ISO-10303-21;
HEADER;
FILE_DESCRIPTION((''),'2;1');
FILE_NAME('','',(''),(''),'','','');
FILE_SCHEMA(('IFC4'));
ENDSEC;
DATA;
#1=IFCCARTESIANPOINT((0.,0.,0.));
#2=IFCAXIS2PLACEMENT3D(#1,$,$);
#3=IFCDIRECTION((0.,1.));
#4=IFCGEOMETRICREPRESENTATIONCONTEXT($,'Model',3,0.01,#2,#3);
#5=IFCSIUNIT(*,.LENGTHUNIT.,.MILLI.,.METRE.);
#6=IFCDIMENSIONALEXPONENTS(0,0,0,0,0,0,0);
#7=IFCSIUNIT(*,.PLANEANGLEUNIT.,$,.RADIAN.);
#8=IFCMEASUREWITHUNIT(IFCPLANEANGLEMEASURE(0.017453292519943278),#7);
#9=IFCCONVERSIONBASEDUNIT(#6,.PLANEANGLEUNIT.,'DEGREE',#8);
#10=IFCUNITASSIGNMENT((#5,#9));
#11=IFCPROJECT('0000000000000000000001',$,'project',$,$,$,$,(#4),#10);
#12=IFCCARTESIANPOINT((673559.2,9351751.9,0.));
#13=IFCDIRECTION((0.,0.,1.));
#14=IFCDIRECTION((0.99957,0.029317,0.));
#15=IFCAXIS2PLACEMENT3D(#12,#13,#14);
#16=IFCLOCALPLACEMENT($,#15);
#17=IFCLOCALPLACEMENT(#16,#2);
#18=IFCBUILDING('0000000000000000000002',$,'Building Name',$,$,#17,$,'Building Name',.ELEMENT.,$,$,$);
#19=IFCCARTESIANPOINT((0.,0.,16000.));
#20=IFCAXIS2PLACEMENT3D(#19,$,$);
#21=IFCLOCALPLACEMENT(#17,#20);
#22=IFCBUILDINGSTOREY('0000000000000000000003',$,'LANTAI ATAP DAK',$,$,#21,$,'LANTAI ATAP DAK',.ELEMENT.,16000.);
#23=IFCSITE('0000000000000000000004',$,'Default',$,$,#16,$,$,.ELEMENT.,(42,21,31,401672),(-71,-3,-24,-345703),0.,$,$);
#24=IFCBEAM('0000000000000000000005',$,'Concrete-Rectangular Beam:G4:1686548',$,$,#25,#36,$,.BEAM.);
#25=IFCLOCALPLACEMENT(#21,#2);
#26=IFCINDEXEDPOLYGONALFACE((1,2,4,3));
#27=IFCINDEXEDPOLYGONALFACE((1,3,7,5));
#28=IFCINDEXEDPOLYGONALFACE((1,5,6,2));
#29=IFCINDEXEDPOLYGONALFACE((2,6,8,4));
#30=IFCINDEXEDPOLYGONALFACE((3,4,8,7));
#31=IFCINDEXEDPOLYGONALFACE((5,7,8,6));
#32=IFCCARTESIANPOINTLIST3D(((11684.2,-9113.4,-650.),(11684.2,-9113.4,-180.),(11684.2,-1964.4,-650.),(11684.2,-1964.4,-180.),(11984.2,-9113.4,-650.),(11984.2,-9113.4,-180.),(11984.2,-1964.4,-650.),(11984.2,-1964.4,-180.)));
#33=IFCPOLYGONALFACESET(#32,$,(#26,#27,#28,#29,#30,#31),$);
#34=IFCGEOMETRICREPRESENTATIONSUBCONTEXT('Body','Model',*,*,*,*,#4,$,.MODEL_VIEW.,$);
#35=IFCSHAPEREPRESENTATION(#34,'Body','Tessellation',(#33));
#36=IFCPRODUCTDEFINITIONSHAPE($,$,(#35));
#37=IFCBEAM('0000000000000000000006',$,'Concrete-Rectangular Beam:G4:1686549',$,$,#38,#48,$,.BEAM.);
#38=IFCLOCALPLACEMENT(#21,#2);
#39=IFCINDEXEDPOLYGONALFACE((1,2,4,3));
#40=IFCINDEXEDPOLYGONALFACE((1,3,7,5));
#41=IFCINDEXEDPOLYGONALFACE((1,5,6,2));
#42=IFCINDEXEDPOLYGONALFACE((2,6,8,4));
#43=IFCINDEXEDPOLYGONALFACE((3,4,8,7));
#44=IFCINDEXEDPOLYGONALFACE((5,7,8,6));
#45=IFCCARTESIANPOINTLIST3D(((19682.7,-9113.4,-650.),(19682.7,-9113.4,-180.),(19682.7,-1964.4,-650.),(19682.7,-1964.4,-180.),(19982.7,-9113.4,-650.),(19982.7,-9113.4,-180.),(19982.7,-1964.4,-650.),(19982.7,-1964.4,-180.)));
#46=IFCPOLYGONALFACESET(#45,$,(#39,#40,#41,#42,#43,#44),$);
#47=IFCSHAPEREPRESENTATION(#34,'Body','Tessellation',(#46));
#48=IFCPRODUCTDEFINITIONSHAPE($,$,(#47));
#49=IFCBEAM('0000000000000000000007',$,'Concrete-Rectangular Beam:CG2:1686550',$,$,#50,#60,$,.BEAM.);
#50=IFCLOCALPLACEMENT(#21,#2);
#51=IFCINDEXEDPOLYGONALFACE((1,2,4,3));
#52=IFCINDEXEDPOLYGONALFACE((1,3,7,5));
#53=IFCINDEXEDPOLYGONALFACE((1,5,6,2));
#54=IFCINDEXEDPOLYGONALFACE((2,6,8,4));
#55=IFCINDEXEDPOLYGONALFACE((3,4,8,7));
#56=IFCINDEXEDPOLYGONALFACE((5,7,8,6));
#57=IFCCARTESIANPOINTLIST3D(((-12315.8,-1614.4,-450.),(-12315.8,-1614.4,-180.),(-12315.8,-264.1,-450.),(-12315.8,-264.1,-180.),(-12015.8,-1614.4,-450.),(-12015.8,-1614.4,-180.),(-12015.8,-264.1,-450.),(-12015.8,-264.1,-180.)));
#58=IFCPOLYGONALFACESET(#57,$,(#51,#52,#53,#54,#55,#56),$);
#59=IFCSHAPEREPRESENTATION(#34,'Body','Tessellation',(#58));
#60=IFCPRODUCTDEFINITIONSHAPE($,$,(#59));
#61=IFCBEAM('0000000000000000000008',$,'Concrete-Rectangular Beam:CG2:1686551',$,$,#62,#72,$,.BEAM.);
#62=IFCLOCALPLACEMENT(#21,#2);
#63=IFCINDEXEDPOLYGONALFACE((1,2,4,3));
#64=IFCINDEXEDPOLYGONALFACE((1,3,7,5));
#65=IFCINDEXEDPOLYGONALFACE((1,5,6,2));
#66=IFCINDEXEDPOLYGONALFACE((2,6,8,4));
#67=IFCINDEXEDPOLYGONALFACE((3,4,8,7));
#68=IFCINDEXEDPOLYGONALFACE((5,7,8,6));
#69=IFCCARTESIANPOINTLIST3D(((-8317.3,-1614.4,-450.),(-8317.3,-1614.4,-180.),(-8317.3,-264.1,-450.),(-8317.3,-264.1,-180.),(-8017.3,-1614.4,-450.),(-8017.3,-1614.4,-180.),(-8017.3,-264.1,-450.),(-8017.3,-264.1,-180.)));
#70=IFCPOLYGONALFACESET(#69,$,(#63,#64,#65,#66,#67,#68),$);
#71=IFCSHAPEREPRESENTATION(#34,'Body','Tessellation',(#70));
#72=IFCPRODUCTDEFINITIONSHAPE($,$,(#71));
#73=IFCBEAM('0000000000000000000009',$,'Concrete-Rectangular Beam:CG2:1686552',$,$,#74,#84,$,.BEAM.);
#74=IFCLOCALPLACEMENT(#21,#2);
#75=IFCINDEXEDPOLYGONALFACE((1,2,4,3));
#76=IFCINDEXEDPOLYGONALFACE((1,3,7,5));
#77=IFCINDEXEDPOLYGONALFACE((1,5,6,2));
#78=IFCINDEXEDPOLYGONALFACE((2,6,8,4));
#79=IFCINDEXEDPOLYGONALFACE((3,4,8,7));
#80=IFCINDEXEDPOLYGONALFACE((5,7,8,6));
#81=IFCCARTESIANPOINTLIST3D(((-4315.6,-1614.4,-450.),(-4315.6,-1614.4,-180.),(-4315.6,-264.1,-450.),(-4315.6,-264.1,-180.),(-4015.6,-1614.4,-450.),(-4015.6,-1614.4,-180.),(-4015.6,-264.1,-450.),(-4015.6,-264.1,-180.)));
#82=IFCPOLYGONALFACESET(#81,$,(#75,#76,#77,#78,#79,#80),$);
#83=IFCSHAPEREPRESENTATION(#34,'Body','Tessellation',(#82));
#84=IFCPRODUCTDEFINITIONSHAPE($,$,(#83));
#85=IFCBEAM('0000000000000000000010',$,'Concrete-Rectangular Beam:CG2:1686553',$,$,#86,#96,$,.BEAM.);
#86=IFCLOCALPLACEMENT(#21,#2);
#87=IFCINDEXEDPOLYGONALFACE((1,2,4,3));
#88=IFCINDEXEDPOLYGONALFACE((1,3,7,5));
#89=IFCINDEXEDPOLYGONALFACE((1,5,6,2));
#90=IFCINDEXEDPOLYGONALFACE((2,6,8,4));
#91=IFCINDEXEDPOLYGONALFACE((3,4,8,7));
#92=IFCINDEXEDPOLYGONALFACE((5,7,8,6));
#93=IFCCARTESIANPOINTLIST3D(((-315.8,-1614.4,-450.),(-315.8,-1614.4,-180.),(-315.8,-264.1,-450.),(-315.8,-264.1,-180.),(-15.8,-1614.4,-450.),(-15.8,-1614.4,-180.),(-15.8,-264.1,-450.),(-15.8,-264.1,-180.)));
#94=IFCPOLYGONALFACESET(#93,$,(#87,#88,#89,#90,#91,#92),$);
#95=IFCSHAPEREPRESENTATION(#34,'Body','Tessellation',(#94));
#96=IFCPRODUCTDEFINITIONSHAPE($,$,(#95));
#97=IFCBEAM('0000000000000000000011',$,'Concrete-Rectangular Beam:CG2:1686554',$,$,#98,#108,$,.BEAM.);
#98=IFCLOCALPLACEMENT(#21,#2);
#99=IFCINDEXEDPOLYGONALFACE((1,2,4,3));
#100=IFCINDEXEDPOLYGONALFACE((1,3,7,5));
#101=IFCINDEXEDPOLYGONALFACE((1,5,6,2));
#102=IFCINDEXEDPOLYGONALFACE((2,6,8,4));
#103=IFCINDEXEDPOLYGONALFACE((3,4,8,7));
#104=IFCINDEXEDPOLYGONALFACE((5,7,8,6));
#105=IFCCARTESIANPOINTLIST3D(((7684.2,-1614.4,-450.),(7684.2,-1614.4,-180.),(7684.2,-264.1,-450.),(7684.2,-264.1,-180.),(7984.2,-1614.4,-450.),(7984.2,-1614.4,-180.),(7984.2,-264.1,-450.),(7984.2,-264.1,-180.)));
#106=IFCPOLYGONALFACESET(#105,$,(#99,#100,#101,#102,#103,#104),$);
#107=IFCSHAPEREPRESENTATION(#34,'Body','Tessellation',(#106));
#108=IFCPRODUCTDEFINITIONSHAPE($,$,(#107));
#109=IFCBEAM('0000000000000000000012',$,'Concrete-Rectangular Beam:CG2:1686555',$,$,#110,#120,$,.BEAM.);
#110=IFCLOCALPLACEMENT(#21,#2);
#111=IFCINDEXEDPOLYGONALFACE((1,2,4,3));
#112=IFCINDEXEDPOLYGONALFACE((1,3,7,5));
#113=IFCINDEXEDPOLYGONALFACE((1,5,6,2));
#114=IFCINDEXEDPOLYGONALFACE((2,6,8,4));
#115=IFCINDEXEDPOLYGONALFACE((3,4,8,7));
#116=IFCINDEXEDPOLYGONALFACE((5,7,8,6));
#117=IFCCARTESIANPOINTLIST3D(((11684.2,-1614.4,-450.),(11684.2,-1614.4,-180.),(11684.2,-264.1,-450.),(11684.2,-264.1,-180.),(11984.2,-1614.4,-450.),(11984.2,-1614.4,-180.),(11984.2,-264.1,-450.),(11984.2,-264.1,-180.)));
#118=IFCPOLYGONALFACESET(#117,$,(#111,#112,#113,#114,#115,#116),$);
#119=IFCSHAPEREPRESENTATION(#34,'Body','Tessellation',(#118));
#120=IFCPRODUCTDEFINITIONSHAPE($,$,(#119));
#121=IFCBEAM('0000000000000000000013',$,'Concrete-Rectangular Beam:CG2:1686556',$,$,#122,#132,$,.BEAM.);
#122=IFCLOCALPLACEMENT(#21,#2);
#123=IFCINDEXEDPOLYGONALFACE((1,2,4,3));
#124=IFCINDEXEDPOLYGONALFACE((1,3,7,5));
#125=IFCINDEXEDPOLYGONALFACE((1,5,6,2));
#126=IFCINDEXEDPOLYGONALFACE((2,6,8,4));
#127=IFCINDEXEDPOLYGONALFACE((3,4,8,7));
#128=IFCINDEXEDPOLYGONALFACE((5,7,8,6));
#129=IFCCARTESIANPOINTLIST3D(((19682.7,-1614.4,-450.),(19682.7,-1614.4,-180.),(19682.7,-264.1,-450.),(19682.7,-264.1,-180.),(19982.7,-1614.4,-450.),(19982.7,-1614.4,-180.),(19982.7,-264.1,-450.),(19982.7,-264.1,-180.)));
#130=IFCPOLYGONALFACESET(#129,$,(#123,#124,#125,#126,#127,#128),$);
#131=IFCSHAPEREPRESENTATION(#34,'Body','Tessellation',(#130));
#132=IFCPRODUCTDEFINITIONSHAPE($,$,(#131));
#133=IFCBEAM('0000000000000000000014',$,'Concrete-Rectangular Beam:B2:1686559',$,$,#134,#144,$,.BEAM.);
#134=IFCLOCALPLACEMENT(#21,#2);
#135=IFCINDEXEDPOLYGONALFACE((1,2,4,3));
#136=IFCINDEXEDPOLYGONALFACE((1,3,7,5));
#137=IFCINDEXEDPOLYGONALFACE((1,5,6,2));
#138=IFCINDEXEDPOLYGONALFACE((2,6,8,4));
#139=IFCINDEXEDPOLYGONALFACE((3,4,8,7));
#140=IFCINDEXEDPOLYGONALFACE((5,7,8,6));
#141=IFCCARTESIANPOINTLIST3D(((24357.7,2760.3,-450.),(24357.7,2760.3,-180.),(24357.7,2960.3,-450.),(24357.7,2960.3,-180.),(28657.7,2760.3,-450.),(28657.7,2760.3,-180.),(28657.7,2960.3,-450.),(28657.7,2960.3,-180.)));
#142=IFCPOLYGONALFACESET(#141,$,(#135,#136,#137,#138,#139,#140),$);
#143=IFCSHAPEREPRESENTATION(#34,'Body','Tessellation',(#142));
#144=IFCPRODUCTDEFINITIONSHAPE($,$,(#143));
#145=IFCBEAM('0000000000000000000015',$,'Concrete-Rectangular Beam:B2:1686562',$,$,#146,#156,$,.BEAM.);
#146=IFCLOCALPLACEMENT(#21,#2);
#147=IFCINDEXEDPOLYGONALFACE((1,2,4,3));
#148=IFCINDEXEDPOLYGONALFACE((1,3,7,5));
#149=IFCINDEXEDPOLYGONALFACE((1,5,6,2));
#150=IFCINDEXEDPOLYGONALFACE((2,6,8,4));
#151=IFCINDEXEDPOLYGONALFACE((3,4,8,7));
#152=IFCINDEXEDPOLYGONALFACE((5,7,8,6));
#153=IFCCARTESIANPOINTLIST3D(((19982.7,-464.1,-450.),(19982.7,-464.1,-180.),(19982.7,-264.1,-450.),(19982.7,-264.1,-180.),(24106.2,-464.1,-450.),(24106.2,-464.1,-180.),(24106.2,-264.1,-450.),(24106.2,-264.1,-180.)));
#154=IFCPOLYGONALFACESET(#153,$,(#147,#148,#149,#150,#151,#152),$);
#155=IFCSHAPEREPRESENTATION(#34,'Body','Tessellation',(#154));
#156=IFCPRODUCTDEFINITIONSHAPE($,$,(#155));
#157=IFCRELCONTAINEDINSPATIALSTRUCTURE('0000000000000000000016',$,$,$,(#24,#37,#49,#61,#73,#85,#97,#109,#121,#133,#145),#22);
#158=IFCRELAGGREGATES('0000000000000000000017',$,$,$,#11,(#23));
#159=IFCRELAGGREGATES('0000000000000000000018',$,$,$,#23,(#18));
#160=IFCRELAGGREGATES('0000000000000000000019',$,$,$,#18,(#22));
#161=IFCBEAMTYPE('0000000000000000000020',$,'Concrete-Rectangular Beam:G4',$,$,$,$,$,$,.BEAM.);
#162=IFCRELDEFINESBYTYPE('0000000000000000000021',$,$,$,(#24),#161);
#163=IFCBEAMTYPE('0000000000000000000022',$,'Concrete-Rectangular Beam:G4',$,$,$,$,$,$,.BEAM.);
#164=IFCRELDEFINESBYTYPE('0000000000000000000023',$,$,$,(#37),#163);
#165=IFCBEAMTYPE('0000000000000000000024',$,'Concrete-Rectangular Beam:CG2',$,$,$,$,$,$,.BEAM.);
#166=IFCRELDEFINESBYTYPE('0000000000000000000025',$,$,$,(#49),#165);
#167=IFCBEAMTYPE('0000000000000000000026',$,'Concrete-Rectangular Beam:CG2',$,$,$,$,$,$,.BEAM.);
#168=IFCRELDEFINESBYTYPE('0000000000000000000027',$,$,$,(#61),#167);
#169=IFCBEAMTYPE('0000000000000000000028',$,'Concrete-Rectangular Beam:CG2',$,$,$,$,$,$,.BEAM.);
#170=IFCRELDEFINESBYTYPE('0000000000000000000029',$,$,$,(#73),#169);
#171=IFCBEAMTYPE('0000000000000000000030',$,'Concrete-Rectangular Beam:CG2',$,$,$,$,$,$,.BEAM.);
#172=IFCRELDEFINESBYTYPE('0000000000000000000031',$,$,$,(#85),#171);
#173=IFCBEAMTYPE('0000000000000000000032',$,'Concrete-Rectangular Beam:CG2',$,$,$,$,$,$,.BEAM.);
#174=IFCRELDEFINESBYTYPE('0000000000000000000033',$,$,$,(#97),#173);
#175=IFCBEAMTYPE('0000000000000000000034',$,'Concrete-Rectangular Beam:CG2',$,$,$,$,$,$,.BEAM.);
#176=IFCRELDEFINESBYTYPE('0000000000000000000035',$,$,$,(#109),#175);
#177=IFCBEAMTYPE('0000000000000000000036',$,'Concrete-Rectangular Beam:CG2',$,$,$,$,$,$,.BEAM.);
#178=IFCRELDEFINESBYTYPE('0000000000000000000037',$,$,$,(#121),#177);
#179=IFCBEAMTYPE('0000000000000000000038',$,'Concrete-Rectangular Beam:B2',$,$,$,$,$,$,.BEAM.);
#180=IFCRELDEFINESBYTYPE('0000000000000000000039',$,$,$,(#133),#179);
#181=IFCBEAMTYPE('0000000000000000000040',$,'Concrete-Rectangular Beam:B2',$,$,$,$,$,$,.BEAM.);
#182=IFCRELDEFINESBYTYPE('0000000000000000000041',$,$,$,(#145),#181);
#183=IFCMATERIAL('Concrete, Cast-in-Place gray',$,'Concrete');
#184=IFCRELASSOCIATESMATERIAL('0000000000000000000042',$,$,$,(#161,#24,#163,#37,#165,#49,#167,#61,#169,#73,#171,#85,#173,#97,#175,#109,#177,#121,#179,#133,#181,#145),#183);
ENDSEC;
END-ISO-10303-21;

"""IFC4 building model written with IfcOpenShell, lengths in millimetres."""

from ifc_helpers import new_model, entity, si_unit, converted_unit, direction, frame, origin, place, context, subcontext, project, spatial, indexed_curve, outline, extrude, source, transform, mapped, material, type_object, type_shapes, element, save


model = new_model("IFC4")

# Units and contexts
model_context = context("Model", 3, precision=0.01, world=origin(), true_north=direction((0.0, 1.0)))
body_context = subcontext(model_context, "Body", "Model", "MODEL_VIEW")
ifc_project = project(units=[si_unit("LENGTHUNIT", "METRE", prefix="MILLI"), converted_unit("PLANEANGLEUNIT", "DEGREE", entity("IfcPlaneAngleMeasure", 0.017453292519943278), si_unit("PLANEANGLEUNIT", "RADIAN"), dimensions=[0, 0, 0, 0, 0, 0, 0])], contexts=[model_context])

# Site, building, storey
site_placement = place(None, frame((673559.2, 9351751.9, 0.0), z_axis=(0.0, 0.0, 1.0), x_axis=(0.99957, 0.029317, 0.0)))
site = spatial("IfcSite", under=ifc_project, at=site_placement, Name="Default", CompositionType="ELEMENT", RefLatitude=(42, 21, 31, 401672), RefLongitude=(-71, -3, -24, -345703), RefElevation=0.0)
building_placement = place(site_placement, origin())
building = spatial("IfcBuilding", under=site, at=building_placement, Name="Building Name", LongName="Building Name", CompositionType="ELEMENT")
storey_placement = place(building_placement, frame((0.0, 0.0, 16000.0)))
storey = spatial("IfcBuildingStorey", under=building, at=storey_placement, Name="LANTAI ATAP DAK", LongName="LANTAI ATAP DAK", CompositionType="ELEMENT", Elevation=16000.0)

# Beams
ifc_material = material(Name="Concrete, Cast-in-Place gray", Category="Concrete")
beam_type_1 = type_object("IfcBeamType", Name="Concrete-Rectangular Beam:G4", PredefinedType="BEAM", material=ifc_material)
shared_shape_1 = source(origin(), body_context, "Body", "SweptSolid", [
    extrude(outline(indexed_curve([(-150.0, -235.0), (150.0, -235.0), (150.0, 235.0), (-150.0, 235.0), (-150.0, -235.0)], self_intersect=False)), frame((11834.2, -9113.4, 15585.0), z_axis=(0.0, 1.0, 0.0), x_axis=(-1.0, 0.0, 0.0)), (0.0, 0.0, 1.0), 7149.0),
])
type_shapes(beam_type_1, [shared_shape_1])
beam_1_placement = place(storey_placement, frame((0.0, 0.0, -16000.0)))
element("IfcBeam", 1, at=beam_1_placement, inside=storey, type_object=beam_type_1, material=ifc_material, Name="Concrete-Rectangular Beam:G4:1686548", PredefinedType="BEAM", context=body_context, shape_type="MappedRepresentation", body=[
    mapped(shared_shape_1, transform((0.0, 0.0, 0.0), scale=1.0)),
])
beam_type_2 = type_object("IfcBeamType", Name="Concrete-Rectangular Beam:G4", PredefinedType="BEAM", material=ifc_material)
shared_shape_2 = source(origin(), body_context, "Body", "SweptSolid", [
    extrude(outline(indexed_curve([(-150.0, -235.0), (150.0, -235.0), (150.0, 235.0), (-150.0, 235.0), (-150.0, -235.0)], self_intersect=False)), frame((19832.7, -9113.4, 15585.0), z_axis=(0.0, 1.0, 0.0), x_axis=(-1.0, 0.0, 0.0)), (0.0, 0.0, 1.0), 7149.0),
])
type_shapes(beam_type_2, [shared_shape_2])
beam_2_placement = place(storey_placement, frame((0.0, 0.0, -16000.0)))
element("IfcBeam", 2, at=beam_2_placement, inside=storey, type_object=beam_type_2, material=ifc_material, Name="Concrete-Rectangular Beam:G4:1686549", PredefinedType="BEAM", context=body_context, shape_type="MappedRepresentation", body=[
    mapped(shared_shape_2, transform((0.0, 0.0, 0.0), scale=1.0)),
])
beam_type_3 = type_object("IfcBeamType", Name="Concrete-Rectangular Beam:CG2", PredefinedType="BEAM", material=ifc_material)
shared_shape_3 = source(origin(), body_context, "Body", "SweptSolid", [
    extrude(outline(indexed_curve([(-150.0, -135.0), (150.0, -135.0), (150.0, 135.0), (-150.0, 135.0), (-150.0, -135.0)], self_intersect=False)), frame((-12165.8, -1614.4, 15685.0), z_axis=(0.0, 1.0, 0.0), x_axis=(-1.0, 0.0, 0.0)), (0.0, 0.0, 1.0), 1350.4),
])
type_shapes(beam_type_3, [shared_shape_3])
beam_3_placement = place(storey_placement, frame((0.0, 0.0, -16000.0)))
element("IfcBeam", 3, at=beam_3_placement, inside=storey, type_object=beam_type_3, material=ifc_material, Name="Concrete-Rectangular Beam:CG2:1686550", PredefinedType="BEAM", context=body_context, shape_type="MappedRepresentation", body=[
    mapped(shared_shape_3, transform((0.0, 0.0, 0.0), scale=1.0)),
])
beam_type_4 = type_object("IfcBeamType", Name="Concrete-Rectangular Beam:CG2", PredefinedType="BEAM", material=ifc_material)
shared_shape_4 = source(origin(), body_context, "Body", "SweptSolid", [
    extrude(outline(indexed_curve([(-150.0, -135.0), (150.0, -135.0), (150.0, 135.0), (-150.0, 135.0), (-150.0, -135.0)], self_intersect=False)), frame((-8167.3, -1614.4, 15685.0), z_axis=(0.0, 1.0, 0.0), x_axis=(-1.0, 0.0, 0.0)), (0.0, 0.0, 1.0), 1350.4),
])
type_shapes(beam_type_4, [shared_shape_4])
beam_4_placement = place(storey_placement, frame((0.0, 0.0, -16000.0)))
element("IfcBeam", 4, at=beam_4_placement, inside=storey, type_object=beam_type_4, material=ifc_material, Name="Concrete-Rectangular Beam:CG2:1686551", PredefinedType="BEAM", context=body_context, shape_type="MappedRepresentation", body=[
    mapped(shared_shape_4, transform((0.0, 0.0, 0.0), scale=1.0)),
])
beam_type_5 = type_object("IfcBeamType", Name="Concrete-Rectangular Beam:CG2", PredefinedType="BEAM", material=ifc_material)
shared_shape_5 = source(origin(), body_context, "Body", "SweptSolid", [
    extrude(outline(indexed_curve([(-150.0, -135.0), (150.0, -135.0), (150.0, 135.0), (-150.0, 135.0), (-150.0, -135.0)], self_intersect=False)), frame((-4165.6, -1614.4, 15685.0), z_axis=(0.0, 1.0, 0.0), x_axis=(-1.0, 0.0, 0.0)), (0.0, 0.0, 1.0), 1350.4),
])
type_shapes(beam_type_5, [shared_shape_5])
beam_5_placement = place(storey_placement, frame((0.0, 0.0, -16000.0)))
element("IfcBeam", 5, at=beam_5_placement, inside=storey, type_object=beam_type_5, material=ifc_material, Name="Concrete-Rectangular Beam:CG2:1686552", PredefinedType="BEAM", context=body_context, shape_type="MappedRepresentation", body=[
    mapped(shared_shape_5, transform((0.0, 0.0, 0.0), scale=1.0)),
])
beam_type_6 = type_object("IfcBeamType", Name="Concrete-Rectangular Beam:CG2", PredefinedType="BEAM", material=ifc_material)
shared_shape_6 = source(origin(), body_context, "Body", "SweptSolid", [
    extrude(outline(indexed_curve([(-150.0, -135.0), (150.0, -135.0), (150.0, 135.0), (-150.0, 135.0), (-150.0, -135.0)], self_intersect=False)), frame((-165.8, -1614.4, 15685.0), z_axis=(0.0, 1.0, 0.0), x_axis=(-1.0, 0.0, 0.0)), (0.0, 0.0, 1.0), 1350.4),
])
type_shapes(beam_type_6, [shared_shape_6])
beam_6_placement = place(storey_placement, frame((0.0, 0.0, -16000.0)))
element("IfcBeam", 6, at=beam_6_placement, inside=storey, type_object=beam_type_6, material=ifc_material, Name="Concrete-Rectangular Beam:CG2:1686553", PredefinedType="BEAM", context=body_context, shape_type="MappedRepresentation", body=[
    mapped(shared_shape_6, transform((0.0, 0.0, 0.0), scale=1.0)),
])
beam_type_7 = type_object("IfcBeamType", Name="Concrete-Rectangular Beam:CG2", PredefinedType="BEAM", material=ifc_material)
shared_shape_7 = source(origin(), body_context, "Body", "SweptSolid", [
    extrude(outline(indexed_curve([(-150.0, -135.0), (150.0, -135.0), (150.0, 135.0), (-150.0, 135.0), (-150.0, -135.0)], self_intersect=False)), frame((7834.2, -1614.4, 15685.0), z_axis=(0.0, 1.0, 0.0), x_axis=(-1.0, 0.0, 0.0)), (0.0, 0.0, 1.0), 1350.4),
])
type_shapes(beam_type_7, [shared_shape_7])
beam_7_placement = place(storey_placement, frame((0.0, 0.0, -16000.0)))
element("IfcBeam", 7, at=beam_7_placement, inside=storey, type_object=beam_type_7, material=ifc_material, Name="Concrete-Rectangular Beam:CG2:1686554", PredefinedType="BEAM", context=body_context, shape_type="MappedRepresentation", body=[
    mapped(shared_shape_7, transform((0.0, 0.0, 0.0), scale=1.0)),
])
beam_type_8 = type_object("IfcBeamType", Name="Concrete-Rectangular Beam:CG2", PredefinedType="BEAM", material=ifc_material)
shared_shape_8 = source(origin(), body_context, "Body", "SweptSolid", [
    extrude(outline(indexed_curve([(-150.0, -135.0), (150.0, -135.0), (150.0, 135.0), (-150.0, 135.0), (-150.0, -135.0)], self_intersect=False)), frame((11834.2, -1614.4, 15685.0), z_axis=(0.0, 1.0, 0.0), x_axis=(-1.0, 0.0, 0.0)), (0.0, 0.0, 1.0), 1350.4),
])
type_shapes(beam_type_8, [shared_shape_8])
beam_8_placement = place(storey_placement, frame((0.0, 0.0, -16000.0)))
element("IfcBeam", 8, at=beam_8_placement, inside=storey, type_object=beam_type_8, material=ifc_material, Name="Concrete-Rectangular Beam:CG2:1686555", PredefinedType="BEAM", context=body_context, shape_type="MappedRepresentation", body=[
    mapped(shared_shape_8, transform((0.0, 0.0, 0.0), scale=1.0)),
])
beam_type_9 = type_object("IfcBeamType", Name="Concrete-Rectangular Beam:CG2", PredefinedType="BEAM", material=ifc_material)
shared_shape_9 = source(origin(), body_context, "Body", "SweptSolid", [
    extrude(outline(indexed_curve([(-150.0, -135.0), (150.0, -135.0), (150.0, 135.0), (-150.0, 135.0), (-150.0, -135.0)], self_intersect=False)), frame((19832.7, -1614.4, 15685.0), z_axis=(0.0, 1.0, 0.0), x_axis=(-1.0, 0.0, 0.0)), (0.0, 0.0, 1.0), 1350.4),
])
type_shapes(beam_type_9, [shared_shape_9])
beam_9_placement = place(storey_placement, frame((0.0, 0.0, -16000.0)))
element("IfcBeam", 9, at=beam_9_placement, inside=storey, type_object=beam_type_9, material=ifc_material, Name="Concrete-Rectangular Beam:CG2:1686556", PredefinedType="BEAM", context=body_context, shape_type="MappedRepresentation", body=[
    mapped(shared_shape_9, transform((0.0, 0.0, 0.0), scale=1.0)),
])
beam_type_10 = type_object("IfcBeamType", Name="Concrete-Rectangular Beam:B2", PredefinedType="BEAM", material=ifc_material)
shared_shape_10 = source(origin(), body_context, "Body", "SweptSolid", [
    extrude(outline(indexed_curve([(-135.0, -100.0), (135.0, -100.0), (135.0, 100.0), (-135.0, 100.0), (-135.0, -100.0)], self_intersect=False)), frame((24357.7, 2860.3, 15685.0), z_axis=(1.0, 0.0, 0.0), x_axis=(0.0, 0.0, -1.0)), (0.0, 0.0, 1.0), 4300.0),
])
type_shapes(beam_type_10, [shared_shape_10])
beam_10_placement = place(storey_placement, frame((0.0, 0.0, -16000.0)))
element("IfcBeam", 10, at=beam_10_placement, inside=storey, type_object=beam_type_10, material=ifc_material, Name="Concrete-Rectangular Beam:B2:1686559", PredefinedType="BEAM", context=body_context, shape_type="MappedRepresentation", body=[
    mapped(shared_shape_10, transform((0.0, 0.0, 0.0), scale=1.0)),
])
beam_type_11 = type_object("IfcBeamType", Name="Concrete-Rectangular Beam:B2", PredefinedType="BEAM", material=ifc_material)
shared_shape_11 = source(origin(), body_context, "Body", "SweptSolid", [
    extrude(outline(indexed_curve([(-135.0, -100.0), (135.0, -100.0), (135.0, 100.0), (-135.0, 100.0), (-135.0, -100.0)], self_intersect=False)), frame((24106.2, -364.1, 15685.0), z_axis=(-1.0, 0.0, 0.0), x_axis=(0.0, 0.0, -1.0)), (0.0, 0.0, 1.0), 4123.5),
])
type_shapes(beam_type_11, [shared_shape_11])
beam_11_placement = place(storey_placement, frame((0.0, 0.0, -16000.0)))
element("IfcBeam", 11, at=beam_11_placement, inside=storey, type_object=beam_type_11, material=ifc_material, Name="Concrete-Rectangular Beam:B2:1686562", PredefinedType="BEAM", context=body_context, shape_type="MappedRepresentation", body=[
    mapped(shared_shape_11, transform((0.0, 0.0, 0.0), scale=1.0)),
])

save(model, "model.ifc")
